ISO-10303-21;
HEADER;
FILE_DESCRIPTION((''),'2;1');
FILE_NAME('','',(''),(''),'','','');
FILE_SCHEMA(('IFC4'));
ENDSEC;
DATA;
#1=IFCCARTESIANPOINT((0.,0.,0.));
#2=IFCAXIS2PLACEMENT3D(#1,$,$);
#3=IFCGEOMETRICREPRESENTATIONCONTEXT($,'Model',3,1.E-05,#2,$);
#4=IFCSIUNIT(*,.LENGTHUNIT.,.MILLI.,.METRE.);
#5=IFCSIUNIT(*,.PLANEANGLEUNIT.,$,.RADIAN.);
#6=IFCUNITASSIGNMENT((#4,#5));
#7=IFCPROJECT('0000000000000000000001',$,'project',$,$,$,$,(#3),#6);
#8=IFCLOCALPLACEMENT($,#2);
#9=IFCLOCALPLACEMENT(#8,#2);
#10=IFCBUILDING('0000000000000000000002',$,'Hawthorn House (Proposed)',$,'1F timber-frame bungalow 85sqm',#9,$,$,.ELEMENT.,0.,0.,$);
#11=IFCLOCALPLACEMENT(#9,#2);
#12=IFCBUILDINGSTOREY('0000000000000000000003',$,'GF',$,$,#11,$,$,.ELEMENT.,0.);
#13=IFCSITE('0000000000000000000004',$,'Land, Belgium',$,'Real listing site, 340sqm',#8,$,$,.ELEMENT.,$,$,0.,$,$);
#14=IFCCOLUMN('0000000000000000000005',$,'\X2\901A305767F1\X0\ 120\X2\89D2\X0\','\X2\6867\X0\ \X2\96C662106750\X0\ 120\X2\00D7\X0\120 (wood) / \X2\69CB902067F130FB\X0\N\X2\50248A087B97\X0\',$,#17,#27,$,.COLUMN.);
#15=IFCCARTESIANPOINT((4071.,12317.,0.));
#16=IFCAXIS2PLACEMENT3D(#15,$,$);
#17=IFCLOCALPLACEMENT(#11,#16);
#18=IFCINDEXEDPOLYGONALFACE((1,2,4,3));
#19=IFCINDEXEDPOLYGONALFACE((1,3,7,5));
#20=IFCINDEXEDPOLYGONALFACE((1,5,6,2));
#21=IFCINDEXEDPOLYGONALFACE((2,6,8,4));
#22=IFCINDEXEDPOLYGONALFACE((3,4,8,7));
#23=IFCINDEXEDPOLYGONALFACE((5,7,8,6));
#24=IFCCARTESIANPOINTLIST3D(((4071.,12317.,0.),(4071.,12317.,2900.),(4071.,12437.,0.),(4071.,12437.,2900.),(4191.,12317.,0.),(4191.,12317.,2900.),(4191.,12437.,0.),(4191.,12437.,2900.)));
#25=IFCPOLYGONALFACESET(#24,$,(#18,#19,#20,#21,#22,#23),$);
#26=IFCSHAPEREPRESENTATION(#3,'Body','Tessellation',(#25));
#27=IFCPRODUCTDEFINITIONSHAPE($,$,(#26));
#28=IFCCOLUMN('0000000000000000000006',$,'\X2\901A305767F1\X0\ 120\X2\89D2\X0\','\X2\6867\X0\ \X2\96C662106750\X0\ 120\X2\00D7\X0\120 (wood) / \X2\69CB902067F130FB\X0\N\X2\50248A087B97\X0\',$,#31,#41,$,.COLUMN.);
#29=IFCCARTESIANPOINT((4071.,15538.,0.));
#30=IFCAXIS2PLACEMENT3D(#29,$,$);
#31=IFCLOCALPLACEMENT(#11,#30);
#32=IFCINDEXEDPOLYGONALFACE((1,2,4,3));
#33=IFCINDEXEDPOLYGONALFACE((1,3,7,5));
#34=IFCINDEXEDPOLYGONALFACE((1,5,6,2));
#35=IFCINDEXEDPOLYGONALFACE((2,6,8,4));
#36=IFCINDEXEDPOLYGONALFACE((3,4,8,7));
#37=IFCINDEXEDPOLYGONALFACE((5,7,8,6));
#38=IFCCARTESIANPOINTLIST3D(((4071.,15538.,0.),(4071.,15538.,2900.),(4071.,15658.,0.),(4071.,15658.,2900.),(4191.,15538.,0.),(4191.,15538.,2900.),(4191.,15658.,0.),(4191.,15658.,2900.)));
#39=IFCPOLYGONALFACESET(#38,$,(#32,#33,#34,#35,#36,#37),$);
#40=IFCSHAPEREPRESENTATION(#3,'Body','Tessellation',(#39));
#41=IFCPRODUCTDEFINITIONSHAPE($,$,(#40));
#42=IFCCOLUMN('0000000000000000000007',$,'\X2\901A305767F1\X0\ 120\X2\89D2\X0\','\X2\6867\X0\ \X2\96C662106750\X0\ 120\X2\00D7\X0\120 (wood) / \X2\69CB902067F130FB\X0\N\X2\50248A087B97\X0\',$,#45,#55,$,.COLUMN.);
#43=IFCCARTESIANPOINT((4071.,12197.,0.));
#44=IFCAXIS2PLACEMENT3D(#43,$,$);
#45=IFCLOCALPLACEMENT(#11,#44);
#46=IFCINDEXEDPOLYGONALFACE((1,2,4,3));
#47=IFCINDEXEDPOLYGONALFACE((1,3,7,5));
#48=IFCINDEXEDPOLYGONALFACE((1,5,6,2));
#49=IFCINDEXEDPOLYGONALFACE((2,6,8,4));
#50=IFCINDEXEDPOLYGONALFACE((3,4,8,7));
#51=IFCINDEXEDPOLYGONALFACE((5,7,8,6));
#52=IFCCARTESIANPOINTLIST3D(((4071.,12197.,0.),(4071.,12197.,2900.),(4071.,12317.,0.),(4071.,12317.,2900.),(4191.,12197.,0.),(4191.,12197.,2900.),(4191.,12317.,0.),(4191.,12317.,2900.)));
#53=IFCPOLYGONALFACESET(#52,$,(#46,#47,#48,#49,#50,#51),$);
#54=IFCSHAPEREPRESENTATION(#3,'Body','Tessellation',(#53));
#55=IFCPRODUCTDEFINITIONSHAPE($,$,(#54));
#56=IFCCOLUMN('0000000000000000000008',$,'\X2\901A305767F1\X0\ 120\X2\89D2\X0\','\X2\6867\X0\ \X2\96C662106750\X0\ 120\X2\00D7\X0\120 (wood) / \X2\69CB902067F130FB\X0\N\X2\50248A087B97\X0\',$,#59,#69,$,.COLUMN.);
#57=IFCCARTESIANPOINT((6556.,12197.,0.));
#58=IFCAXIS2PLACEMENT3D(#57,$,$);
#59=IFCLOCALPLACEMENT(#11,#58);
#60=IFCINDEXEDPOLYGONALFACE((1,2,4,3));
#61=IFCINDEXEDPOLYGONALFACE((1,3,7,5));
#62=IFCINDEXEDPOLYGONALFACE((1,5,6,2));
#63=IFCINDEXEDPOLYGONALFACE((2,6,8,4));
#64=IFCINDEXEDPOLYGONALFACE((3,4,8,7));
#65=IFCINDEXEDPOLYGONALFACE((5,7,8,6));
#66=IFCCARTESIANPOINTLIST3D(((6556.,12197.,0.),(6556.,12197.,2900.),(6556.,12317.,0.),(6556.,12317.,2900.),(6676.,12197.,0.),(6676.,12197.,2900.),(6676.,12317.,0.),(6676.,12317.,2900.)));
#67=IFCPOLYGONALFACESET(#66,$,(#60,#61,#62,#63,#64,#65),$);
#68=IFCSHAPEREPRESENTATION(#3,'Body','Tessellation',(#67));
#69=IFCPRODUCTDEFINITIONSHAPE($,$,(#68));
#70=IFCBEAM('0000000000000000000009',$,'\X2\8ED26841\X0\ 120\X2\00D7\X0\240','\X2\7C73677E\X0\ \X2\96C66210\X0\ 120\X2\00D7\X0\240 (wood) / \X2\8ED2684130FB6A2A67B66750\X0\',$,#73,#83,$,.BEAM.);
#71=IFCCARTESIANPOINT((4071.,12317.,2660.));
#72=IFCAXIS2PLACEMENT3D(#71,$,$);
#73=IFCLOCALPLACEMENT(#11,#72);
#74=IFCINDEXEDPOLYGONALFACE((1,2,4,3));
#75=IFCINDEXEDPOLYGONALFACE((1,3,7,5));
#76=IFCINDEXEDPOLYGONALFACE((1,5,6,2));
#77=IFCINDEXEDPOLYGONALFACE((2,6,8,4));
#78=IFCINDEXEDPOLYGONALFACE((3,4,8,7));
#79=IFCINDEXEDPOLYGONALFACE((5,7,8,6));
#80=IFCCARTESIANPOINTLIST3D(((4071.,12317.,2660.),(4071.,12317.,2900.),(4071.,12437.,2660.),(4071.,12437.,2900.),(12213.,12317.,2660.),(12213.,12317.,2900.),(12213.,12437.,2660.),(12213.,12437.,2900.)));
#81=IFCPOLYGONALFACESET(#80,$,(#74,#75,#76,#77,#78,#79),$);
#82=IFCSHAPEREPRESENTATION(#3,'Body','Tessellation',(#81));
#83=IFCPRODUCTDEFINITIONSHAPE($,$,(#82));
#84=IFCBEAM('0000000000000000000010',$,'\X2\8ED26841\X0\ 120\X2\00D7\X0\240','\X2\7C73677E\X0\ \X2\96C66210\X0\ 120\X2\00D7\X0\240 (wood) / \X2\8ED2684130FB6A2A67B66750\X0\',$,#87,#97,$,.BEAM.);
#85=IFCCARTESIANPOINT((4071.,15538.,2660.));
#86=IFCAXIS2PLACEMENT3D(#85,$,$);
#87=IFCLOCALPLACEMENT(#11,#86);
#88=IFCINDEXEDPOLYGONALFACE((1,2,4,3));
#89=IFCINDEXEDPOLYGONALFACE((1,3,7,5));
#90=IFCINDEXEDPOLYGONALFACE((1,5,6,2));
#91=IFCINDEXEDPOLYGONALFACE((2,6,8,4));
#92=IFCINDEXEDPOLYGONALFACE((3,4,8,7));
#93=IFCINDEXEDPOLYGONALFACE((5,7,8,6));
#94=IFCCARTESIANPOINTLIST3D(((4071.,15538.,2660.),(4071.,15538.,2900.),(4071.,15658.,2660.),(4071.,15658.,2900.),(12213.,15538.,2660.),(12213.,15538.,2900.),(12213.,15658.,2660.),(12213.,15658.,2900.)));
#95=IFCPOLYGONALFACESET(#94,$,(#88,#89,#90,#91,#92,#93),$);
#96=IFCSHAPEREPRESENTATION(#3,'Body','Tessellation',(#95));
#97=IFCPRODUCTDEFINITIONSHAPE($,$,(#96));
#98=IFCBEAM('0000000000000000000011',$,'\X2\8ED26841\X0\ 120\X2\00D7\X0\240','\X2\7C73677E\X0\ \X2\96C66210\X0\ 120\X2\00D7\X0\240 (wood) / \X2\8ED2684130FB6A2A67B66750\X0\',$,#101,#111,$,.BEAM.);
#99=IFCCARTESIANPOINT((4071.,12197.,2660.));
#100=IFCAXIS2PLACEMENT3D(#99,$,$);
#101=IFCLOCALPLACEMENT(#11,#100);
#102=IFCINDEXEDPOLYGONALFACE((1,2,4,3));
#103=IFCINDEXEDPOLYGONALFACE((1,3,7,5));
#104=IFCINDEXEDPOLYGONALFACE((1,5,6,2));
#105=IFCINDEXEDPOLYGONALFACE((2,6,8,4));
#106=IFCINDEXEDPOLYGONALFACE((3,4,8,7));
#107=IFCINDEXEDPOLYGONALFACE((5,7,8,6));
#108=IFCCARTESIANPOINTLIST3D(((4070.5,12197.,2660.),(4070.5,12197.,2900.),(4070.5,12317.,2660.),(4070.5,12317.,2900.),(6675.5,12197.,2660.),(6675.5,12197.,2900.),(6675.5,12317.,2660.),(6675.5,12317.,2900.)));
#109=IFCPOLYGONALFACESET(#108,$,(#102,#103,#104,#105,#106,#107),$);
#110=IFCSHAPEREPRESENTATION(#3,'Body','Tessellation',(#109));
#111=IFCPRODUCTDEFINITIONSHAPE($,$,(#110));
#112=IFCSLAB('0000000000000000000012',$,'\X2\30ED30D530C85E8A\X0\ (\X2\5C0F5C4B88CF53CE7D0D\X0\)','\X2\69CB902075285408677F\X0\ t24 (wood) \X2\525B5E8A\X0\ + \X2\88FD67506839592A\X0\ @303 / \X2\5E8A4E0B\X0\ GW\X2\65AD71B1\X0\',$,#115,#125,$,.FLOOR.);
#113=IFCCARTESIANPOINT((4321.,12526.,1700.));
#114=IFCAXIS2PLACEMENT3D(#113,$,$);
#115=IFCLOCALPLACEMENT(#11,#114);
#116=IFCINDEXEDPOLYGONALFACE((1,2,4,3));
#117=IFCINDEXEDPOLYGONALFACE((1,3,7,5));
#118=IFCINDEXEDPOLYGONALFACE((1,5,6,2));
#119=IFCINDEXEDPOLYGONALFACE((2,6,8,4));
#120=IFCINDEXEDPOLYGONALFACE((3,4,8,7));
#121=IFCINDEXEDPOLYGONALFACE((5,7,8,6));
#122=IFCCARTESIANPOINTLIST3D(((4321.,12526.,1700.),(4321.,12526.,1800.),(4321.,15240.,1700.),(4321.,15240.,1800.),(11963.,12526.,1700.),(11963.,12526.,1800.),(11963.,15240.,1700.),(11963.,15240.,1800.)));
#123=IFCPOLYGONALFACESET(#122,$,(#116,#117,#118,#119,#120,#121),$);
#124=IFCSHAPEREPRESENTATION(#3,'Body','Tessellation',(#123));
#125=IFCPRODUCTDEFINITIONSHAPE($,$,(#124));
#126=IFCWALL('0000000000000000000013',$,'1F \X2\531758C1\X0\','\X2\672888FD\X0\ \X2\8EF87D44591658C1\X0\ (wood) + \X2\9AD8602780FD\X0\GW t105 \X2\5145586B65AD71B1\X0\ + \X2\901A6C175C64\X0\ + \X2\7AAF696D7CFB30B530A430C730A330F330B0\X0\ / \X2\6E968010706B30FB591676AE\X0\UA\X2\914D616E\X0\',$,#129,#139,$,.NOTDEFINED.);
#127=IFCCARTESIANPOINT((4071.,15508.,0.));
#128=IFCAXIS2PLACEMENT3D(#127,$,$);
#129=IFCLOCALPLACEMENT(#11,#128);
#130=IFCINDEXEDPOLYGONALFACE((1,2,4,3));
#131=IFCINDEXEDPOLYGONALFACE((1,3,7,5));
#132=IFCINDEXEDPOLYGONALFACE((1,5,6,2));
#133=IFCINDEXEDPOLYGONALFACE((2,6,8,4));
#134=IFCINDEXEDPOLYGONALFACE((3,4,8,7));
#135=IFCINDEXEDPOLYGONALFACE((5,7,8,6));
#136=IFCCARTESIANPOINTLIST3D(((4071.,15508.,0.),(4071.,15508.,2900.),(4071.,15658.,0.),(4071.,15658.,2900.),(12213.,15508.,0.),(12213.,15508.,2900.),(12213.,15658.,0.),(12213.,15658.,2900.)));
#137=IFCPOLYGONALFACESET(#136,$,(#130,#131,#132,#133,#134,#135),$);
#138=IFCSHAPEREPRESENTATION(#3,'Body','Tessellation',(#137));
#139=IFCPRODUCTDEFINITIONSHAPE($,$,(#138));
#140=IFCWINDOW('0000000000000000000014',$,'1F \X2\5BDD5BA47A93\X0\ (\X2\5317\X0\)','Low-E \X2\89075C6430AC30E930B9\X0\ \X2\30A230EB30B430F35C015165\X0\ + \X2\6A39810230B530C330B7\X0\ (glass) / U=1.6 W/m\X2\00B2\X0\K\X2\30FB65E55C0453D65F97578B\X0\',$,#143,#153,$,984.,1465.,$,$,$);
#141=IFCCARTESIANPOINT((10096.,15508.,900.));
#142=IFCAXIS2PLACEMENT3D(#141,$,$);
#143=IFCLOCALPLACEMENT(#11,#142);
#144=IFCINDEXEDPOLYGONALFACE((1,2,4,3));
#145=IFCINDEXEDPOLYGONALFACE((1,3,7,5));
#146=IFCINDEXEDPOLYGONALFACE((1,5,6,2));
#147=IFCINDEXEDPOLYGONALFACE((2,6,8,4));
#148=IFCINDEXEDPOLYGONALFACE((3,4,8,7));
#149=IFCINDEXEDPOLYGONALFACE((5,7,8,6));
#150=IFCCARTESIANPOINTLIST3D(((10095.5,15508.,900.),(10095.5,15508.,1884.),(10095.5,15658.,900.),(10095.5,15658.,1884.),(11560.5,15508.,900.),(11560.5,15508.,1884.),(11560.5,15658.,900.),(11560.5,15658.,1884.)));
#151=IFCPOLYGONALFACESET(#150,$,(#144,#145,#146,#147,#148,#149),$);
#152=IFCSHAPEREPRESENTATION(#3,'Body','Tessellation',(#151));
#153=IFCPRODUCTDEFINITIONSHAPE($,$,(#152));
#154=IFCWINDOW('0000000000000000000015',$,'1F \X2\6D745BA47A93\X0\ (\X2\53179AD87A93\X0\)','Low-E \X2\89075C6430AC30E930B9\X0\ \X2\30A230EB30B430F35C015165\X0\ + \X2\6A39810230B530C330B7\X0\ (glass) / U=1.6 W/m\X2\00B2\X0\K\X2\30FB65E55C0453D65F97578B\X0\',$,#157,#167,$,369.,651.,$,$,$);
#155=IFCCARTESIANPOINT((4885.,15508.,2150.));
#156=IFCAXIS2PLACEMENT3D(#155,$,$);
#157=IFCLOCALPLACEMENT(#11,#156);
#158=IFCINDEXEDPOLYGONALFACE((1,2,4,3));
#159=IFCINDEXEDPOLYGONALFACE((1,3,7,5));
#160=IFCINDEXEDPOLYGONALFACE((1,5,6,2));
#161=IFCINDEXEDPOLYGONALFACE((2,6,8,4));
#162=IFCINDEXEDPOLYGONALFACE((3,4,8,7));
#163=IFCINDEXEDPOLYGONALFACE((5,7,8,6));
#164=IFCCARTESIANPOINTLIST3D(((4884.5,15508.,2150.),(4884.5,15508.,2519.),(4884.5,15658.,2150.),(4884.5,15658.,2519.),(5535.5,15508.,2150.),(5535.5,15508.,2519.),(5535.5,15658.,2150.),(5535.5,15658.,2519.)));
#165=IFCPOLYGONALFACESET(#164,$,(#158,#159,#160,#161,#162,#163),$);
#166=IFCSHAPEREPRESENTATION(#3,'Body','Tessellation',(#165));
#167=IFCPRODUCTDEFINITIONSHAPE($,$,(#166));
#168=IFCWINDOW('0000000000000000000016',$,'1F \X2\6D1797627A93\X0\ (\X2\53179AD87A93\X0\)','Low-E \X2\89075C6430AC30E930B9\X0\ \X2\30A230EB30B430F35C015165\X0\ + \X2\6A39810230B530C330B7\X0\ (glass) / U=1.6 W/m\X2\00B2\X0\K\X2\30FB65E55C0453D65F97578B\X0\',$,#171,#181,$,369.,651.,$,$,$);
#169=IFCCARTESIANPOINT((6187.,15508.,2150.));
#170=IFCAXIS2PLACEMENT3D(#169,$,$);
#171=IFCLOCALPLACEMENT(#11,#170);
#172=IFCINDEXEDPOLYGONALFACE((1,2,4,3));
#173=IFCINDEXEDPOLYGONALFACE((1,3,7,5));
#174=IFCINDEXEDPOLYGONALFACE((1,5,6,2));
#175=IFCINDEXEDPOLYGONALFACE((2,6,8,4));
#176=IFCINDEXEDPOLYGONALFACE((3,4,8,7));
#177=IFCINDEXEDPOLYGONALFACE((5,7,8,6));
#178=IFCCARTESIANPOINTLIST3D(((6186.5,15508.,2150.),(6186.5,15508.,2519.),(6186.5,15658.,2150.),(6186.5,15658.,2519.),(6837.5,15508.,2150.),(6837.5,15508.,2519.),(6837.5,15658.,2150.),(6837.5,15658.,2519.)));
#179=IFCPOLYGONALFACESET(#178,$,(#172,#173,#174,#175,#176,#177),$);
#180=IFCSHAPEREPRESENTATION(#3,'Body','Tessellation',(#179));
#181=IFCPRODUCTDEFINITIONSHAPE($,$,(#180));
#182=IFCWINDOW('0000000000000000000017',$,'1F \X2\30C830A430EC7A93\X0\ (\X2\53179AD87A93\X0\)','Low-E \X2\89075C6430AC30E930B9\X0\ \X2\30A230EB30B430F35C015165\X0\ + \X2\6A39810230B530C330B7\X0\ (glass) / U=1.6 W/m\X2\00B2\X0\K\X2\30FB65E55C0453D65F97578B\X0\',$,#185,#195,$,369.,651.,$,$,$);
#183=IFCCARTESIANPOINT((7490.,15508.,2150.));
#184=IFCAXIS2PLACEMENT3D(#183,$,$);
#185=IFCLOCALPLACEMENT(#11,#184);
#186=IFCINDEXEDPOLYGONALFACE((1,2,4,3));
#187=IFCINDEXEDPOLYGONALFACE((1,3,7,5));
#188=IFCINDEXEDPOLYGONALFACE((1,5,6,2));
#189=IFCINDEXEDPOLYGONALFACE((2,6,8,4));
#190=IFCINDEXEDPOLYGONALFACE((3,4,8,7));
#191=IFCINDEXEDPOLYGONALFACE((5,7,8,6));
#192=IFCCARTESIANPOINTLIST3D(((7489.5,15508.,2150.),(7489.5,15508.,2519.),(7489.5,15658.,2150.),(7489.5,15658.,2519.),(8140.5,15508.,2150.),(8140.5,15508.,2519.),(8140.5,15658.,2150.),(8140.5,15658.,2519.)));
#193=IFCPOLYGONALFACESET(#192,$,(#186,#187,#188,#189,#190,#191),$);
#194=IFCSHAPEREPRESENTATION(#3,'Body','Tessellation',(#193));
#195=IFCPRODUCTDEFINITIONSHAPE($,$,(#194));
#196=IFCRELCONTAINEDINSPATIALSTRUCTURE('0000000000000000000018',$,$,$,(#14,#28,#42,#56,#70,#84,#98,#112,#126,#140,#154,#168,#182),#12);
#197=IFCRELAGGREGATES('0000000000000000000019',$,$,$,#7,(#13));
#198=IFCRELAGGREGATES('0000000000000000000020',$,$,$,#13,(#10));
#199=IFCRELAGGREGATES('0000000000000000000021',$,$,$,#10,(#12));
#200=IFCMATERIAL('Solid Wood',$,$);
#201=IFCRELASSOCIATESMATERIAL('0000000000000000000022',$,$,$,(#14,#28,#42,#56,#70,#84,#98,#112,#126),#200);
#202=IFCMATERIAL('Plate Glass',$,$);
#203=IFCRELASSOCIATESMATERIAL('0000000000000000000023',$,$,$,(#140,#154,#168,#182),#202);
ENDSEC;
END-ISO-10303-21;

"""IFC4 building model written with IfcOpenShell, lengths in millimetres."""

from ifc_helpers import new_model, si_unit, frame, frame_2d, origin, place, context, project, spatial, rectangle, extrude, material, element, fill, save


model = new_model("IFC4")

# Units and contexts
model_context = context("Model", 3, precision=1e-05, world=origin())
ifc_project = project(units=[si_unit("LENGTHUNIT", "METRE", prefix="MILLI"), si_unit("PLANEANGLEUNIT", "RADIAN")], contexts=[model_context])

# Site, building, storey
site_placement = place(None, origin())
site = spatial("IfcSite", under=ifc_project, at=site_placement, Name="Land, Belgium", ObjectType="Real listing site, 340sqm", CompositionType="ELEMENT", RefElevation=0.0)
building_placement = place(site_placement, origin())
building = spatial("IfcBuilding", under=site, at=building_placement, Name="Hawthorn House (Proposed)", ObjectType="1F timber-frame bungalow 85sqm", CompositionType="ELEMENT", ElevationOfRefHeight=0.0, ElevationOfTerrain=0.0)
storey_placement = place(building_placement, origin())
storey = spatial("IfcBuildingStorey", under=building, at=storey_placement, Name="GF", CompositionType="ELEMENT", Elevation=0.0)

# Columns
ifc_material_1 = material(Name="Solid Wood")
column_1_placement = place(storey_placement, frame((4071.0, 12317.0, 0.0)))
element("IfcColumn", 1, at=column_1_placement, inside=storey, material=ifc_material_1, Name="通し柱 120角", Description="桧 集成材 120×120 (wood) / 構造柱・N値計算", PredefinedType="COLUMN", context=model_context, shape_type="SweptSolid", body=[
    extrude(rectangle(XDim=120.0, YDim=120.0, at=frame_2d((60.0, 60.0))), frame((4071.0, 12317.0, 0.0)), (0.0, 0.0, 1.0), 2900.0),
])
column_2_placement = place(storey_placement, frame((4071.0, 15538.0, 0.0)))
element("IfcColumn", 2, at=column_2_placement, inside=storey, material=ifc_material_1, Name="通し柱 120角", Description="桧 集成材 120×120 (wood) / 構造柱・N値計算", PredefinedType="COLUMN", context=model_context, shape_type="SweptSolid", body=[
    extrude(rectangle(XDim=120.0, YDim=120.0, at=frame_2d((60.0, 60.0))), frame((4071.0, 15538.0, 0.0)), (0.0, 0.0, 1.0), 2900.0),
])
column_3_placement = place(storey_placement, frame((4071.0, 12197.0, 0.0)))
element("IfcColumn", 3, at=column_3_placement, inside=storey, material=ifc_material_1, Name="通し柱 120角", Description="桧 集成材 120×120 (wood) / 構造柱・N値計算", PredefinedType="COLUMN", context=model_context, shape_type="SweptSolid", body=[
    extrude(rectangle(XDim=120.0, YDim=120.0, at=frame_2d((60.0, 60.0))), frame((4071.0, 12197.0, 0.0)), (0.0, 0.0, 1.0), 2900.0),
])
column_4_placement = place(storey_placement, frame((6556.0, 12197.0, 0.0)))
element("IfcColumn", 4, at=column_4_placement, inside=storey, material=ifc_material_1, Name="通し柱 120角", Description="桧 集成材 120×120 (wood) / 構造柱・N値計算", PredefinedType="COLUMN", context=model_context, shape_type="SweptSolid", body=[
    extrude(rectangle(XDim=120.0, YDim=120.0, at=frame_2d((60.0, 60.0))), frame((6556.0, 12197.0, 0.0)), (0.0, 0.0, 1.0), 2900.0),
])

# Beams
beam_1_placement = place(storey_placement, frame((4071.0, 12317.0, 2660.0)))
element("IfcBeam", 5, at=beam_1_placement, inside=storey, material=ifc_material_1, Name="軒桁 120×240", Description="米松 集成 120×240 (wood) / 軒桁・横架材", PredefinedType="BEAM", context=model_context, shape_type="SweptSolid", body=[
    extrude(rectangle(XDim=8142.0, YDim=120.0, at=frame_2d((4071.0, 60.0))), frame((4071.0, 12317.0, 2660.0)), (0.0, 0.0, 1.0), 240.0),
])
beam_2_placement = place(storey_placement, frame((4071.0, 15538.0, 2660.0)))
element("IfcBeam", 6, at=beam_2_placement, inside=storey, material=ifc_material_1, Name="軒桁 120×240", Description="米松 集成 120×240 (wood) / 軒桁・横架材", PredefinedType="BEAM", context=model_context, shape_type="SweptSolid", body=[
    extrude(rectangle(XDim=8142.0, YDim=120.0, at=frame_2d((4071.0, 60.0))), frame((4071.0, 15538.0, 2660.0)), (0.0, 0.0, 1.0), 240.0),
])
beam_3_placement = place(storey_placement, frame((4071.0, 12197.0, 2660.0)))
element("IfcBeam", 7, at=beam_3_placement, inside=storey, material=ifc_material_1, Name="軒桁 120×240", Description="米松 集成 120×240 (wood) / 軒桁・横架材", PredefinedType="BEAM", context=model_context, shape_type="SweptSolid", body=[
    extrude(rectangle(XDim=2605.0, YDim=120.0, at=frame_2d((1302.0, 60.0))), frame((4071.0, 12197.0, 2660.0)), (0.0, 0.0, 1.0), 240.0),
])

# Slab
slab_1_placement = place(storey_placement, frame((4321.0, 12526.0, 1700.0)))
element("IfcSlab", 8, at=slab_1_placement, inside=storey, material=ifc_material_1, Name="ロフト床 (小屋裏収納)", Description="構造用合板 t24 (wood) 剛床 + 製材根太 @303 / 床下 GW断熱", PredefinedType="FLOOR", context=model_context, shape_type="SweptSolid", body=[
    extrude(rectangle(XDim=7642.0, YDim=2714.0, at=frame_2d((3821.0, 1357.0))), frame((4321.0, 12526.0, 1700.0)), (0.0, 0.0, 1.0), 100.0),
])

# Wall, openings, windows
wall_1_placement = place(storey_placement, frame((4071.0, 15508.0, 0.0)))
wall_1 = element("IfcWall", 9, at=wall_1_placement, inside=storey, material=ifc_material_1, Name="1F 北壁", Description="木製 軸組外壁 (wood) + 高性能GW t105 充填断熱 + 通気層 + 窯業系サイディング / 準耐火・外皮UA配慮", PredefinedType="NOTDEFINED", context=model_context, shape_type="SweptSolid", body=[
    extrude(rectangle(XDim=8142.0, YDim=150.0, at=frame_2d((4071.0, 75.0))), frame((4071.0, 15508.0, 0.0)), (0.0, 0.0, 1.0), 2900.0),
])
opening_1_placement = place(storey_placement, frame((10096.0, 15508.0, 900.0)))
opening_1 = element("IfcOpeningElement", 10, at=opening_1_placement, cuts=wall_1, PredefinedType="NOTDEFINED", context=model_context, shape_type="SweptSolid", body=[
    extrude(rectangle(XDim=1465.0, YDim=150.0, at=frame_2d((732.0, 75.0))), frame((10096.0, 15508.0, 900.0)), (0.0, 0.0, 1.0), 984.0),
])
opening_2_placement = place(storey_placement, frame((4885.0, 15508.0, 2150.0)))
opening_2 = element("IfcOpeningElement", 11, at=opening_2_placement, cuts=wall_1, PredefinedType="NOTDEFINED", context=model_context, shape_type="SweptSolid", body=[
    extrude(rectangle(XDim=651.0, YDim=150.0, at=frame_2d((325.0, 75.0))), frame((4885.0, 15508.0, 2150.0)), (0.0, 0.0, 1.0), 369.0),
])
opening_3_placement = place(storey_placement, frame((6187.0, 15508.0, 2150.0)))
opening_3 = element("IfcOpeningElement", 12, at=opening_3_placement, cuts=wall_1, PredefinedType="NOTDEFINED", context=model_context, shape_type="SweptSolid", body=[
    extrude(rectangle(XDim=651.0, YDim=150.0, at=frame_2d((325.0, 75.0))), frame((6187.0, 15508.0, 2150.0)), (0.0, 0.0, 1.0), 369.0),
])
opening_4_placement = place(storey_placement, frame((7490.0, 15508.0, 2150.0)))
opening_4 = element("IfcOpeningElement", 13, at=opening_4_placement, cuts=wall_1, PredefinedType="NOTDEFINED", context=model_context, shape_type="SweptSolid", body=[
    extrude(rectangle(XDim=651.0, YDim=150.0, at=frame_2d((325.0, 75.0))), frame((7490.0, 15508.0, 2150.0)), (0.0, 0.0, 1.0), 369.0),
])
ifc_material_2 = material(Name="Plate Glass")
window_1_placement = place(storey_placement, frame((10096.0, 15508.0, 900.0)))
window_1 = element("IfcWindow", 14, at=window_1_placement, inside=storey, material=ifc_material_2, Name="1F 寝室窓 (北)", Description="Low-E 複層ガラス アルゴン封入 + 樹脂サッシ (glass) / U=1.6 W/m²K・日射取得型", OverallHeight=984.0, OverallWidth=1465.0, context=model_context, shape_type="SweptSolid", body=[
    extrude(rectangle(XDim=1465.0, YDim=150.0, at=frame_2d((732.0, 75.0))), frame((10096.0, 15508.0, 900.0)), (0.0, 0.0, 1.0), 984.0),
])
fill(opening_1, window_1)
window_2_placement = place(storey_placement, frame((4885.0, 15508.0, 2150.0)))
window_2 = element("IfcWindow", 15, at=window_2_placement, inside=storey, material=ifc_material_2, Name="1F 浴室窓 (北高窓)", Description="Low-E 複層ガラス アルゴン封入 + 樹脂サッシ (glass) / U=1.6 W/m²K・日射取得型", OverallHeight=369.0, OverallWidth=651.0, context=model_context, shape_type="SweptSolid", body=[
    extrude(rectangle(XDim=651.0, YDim=150.0, at=frame_2d((325.0, 75.0))), frame((4885.0, 15508.0, 2150.0)), (0.0, 0.0, 1.0), 369.0),
])
fill(opening_2, window_2)
window_3_placement = place(storey_placement, frame((6187.0, 15508.0, 2150.0)))
window_3 = element("IfcWindow", 16, at=window_3_placement, inside=storey, material=ifc_material_2, Name="1F 洗面窓 (北高窓)", Description="Low-E 複層ガラス アルゴン封入 + 樹脂サッシ (glass) / U=1.6 W/m²K・日射取得型", OverallHeight=369.0, OverallWidth=651.0, context=model_context, shape_type="SweptSolid", body=[
    extrude(rectangle(XDim=651.0, YDim=150.0, at=frame_2d((325.0, 75.0))), frame((6187.0, 15508.0, 2150.0)), (0.0, 0.0, 1.0), 369.0),
])
fill(opening_3, window_3)
window_4_placement = place(storey_placement, frame((7490.0, 15508.0, 2150.0)))
window_4 = element("IfcWindow", 17, at=window_4_placement, inside=storey, material=ifc_material_2, Name="1F トイレ窓 (北高窓)", Description="Low-E 複層ガラス アルゴン封入 + 樹脂サッシ (glass) / U=1.6 W/m²K・日射取得型", OverallHeight=369.0, OverallWidth=651.0, context=model_context, shape_type="SweptSolid", body=[
    extrude(rectangle(XDim=651.0, YDim=150.0, at=frame_2d((325.0, 75.0))), frame((7490.0, 15508.0, 2150.0)), (0.0, 0.0, 1.0), 369.0),
])
fill(opening_4, window_4)

save(model, "model.ifc")
